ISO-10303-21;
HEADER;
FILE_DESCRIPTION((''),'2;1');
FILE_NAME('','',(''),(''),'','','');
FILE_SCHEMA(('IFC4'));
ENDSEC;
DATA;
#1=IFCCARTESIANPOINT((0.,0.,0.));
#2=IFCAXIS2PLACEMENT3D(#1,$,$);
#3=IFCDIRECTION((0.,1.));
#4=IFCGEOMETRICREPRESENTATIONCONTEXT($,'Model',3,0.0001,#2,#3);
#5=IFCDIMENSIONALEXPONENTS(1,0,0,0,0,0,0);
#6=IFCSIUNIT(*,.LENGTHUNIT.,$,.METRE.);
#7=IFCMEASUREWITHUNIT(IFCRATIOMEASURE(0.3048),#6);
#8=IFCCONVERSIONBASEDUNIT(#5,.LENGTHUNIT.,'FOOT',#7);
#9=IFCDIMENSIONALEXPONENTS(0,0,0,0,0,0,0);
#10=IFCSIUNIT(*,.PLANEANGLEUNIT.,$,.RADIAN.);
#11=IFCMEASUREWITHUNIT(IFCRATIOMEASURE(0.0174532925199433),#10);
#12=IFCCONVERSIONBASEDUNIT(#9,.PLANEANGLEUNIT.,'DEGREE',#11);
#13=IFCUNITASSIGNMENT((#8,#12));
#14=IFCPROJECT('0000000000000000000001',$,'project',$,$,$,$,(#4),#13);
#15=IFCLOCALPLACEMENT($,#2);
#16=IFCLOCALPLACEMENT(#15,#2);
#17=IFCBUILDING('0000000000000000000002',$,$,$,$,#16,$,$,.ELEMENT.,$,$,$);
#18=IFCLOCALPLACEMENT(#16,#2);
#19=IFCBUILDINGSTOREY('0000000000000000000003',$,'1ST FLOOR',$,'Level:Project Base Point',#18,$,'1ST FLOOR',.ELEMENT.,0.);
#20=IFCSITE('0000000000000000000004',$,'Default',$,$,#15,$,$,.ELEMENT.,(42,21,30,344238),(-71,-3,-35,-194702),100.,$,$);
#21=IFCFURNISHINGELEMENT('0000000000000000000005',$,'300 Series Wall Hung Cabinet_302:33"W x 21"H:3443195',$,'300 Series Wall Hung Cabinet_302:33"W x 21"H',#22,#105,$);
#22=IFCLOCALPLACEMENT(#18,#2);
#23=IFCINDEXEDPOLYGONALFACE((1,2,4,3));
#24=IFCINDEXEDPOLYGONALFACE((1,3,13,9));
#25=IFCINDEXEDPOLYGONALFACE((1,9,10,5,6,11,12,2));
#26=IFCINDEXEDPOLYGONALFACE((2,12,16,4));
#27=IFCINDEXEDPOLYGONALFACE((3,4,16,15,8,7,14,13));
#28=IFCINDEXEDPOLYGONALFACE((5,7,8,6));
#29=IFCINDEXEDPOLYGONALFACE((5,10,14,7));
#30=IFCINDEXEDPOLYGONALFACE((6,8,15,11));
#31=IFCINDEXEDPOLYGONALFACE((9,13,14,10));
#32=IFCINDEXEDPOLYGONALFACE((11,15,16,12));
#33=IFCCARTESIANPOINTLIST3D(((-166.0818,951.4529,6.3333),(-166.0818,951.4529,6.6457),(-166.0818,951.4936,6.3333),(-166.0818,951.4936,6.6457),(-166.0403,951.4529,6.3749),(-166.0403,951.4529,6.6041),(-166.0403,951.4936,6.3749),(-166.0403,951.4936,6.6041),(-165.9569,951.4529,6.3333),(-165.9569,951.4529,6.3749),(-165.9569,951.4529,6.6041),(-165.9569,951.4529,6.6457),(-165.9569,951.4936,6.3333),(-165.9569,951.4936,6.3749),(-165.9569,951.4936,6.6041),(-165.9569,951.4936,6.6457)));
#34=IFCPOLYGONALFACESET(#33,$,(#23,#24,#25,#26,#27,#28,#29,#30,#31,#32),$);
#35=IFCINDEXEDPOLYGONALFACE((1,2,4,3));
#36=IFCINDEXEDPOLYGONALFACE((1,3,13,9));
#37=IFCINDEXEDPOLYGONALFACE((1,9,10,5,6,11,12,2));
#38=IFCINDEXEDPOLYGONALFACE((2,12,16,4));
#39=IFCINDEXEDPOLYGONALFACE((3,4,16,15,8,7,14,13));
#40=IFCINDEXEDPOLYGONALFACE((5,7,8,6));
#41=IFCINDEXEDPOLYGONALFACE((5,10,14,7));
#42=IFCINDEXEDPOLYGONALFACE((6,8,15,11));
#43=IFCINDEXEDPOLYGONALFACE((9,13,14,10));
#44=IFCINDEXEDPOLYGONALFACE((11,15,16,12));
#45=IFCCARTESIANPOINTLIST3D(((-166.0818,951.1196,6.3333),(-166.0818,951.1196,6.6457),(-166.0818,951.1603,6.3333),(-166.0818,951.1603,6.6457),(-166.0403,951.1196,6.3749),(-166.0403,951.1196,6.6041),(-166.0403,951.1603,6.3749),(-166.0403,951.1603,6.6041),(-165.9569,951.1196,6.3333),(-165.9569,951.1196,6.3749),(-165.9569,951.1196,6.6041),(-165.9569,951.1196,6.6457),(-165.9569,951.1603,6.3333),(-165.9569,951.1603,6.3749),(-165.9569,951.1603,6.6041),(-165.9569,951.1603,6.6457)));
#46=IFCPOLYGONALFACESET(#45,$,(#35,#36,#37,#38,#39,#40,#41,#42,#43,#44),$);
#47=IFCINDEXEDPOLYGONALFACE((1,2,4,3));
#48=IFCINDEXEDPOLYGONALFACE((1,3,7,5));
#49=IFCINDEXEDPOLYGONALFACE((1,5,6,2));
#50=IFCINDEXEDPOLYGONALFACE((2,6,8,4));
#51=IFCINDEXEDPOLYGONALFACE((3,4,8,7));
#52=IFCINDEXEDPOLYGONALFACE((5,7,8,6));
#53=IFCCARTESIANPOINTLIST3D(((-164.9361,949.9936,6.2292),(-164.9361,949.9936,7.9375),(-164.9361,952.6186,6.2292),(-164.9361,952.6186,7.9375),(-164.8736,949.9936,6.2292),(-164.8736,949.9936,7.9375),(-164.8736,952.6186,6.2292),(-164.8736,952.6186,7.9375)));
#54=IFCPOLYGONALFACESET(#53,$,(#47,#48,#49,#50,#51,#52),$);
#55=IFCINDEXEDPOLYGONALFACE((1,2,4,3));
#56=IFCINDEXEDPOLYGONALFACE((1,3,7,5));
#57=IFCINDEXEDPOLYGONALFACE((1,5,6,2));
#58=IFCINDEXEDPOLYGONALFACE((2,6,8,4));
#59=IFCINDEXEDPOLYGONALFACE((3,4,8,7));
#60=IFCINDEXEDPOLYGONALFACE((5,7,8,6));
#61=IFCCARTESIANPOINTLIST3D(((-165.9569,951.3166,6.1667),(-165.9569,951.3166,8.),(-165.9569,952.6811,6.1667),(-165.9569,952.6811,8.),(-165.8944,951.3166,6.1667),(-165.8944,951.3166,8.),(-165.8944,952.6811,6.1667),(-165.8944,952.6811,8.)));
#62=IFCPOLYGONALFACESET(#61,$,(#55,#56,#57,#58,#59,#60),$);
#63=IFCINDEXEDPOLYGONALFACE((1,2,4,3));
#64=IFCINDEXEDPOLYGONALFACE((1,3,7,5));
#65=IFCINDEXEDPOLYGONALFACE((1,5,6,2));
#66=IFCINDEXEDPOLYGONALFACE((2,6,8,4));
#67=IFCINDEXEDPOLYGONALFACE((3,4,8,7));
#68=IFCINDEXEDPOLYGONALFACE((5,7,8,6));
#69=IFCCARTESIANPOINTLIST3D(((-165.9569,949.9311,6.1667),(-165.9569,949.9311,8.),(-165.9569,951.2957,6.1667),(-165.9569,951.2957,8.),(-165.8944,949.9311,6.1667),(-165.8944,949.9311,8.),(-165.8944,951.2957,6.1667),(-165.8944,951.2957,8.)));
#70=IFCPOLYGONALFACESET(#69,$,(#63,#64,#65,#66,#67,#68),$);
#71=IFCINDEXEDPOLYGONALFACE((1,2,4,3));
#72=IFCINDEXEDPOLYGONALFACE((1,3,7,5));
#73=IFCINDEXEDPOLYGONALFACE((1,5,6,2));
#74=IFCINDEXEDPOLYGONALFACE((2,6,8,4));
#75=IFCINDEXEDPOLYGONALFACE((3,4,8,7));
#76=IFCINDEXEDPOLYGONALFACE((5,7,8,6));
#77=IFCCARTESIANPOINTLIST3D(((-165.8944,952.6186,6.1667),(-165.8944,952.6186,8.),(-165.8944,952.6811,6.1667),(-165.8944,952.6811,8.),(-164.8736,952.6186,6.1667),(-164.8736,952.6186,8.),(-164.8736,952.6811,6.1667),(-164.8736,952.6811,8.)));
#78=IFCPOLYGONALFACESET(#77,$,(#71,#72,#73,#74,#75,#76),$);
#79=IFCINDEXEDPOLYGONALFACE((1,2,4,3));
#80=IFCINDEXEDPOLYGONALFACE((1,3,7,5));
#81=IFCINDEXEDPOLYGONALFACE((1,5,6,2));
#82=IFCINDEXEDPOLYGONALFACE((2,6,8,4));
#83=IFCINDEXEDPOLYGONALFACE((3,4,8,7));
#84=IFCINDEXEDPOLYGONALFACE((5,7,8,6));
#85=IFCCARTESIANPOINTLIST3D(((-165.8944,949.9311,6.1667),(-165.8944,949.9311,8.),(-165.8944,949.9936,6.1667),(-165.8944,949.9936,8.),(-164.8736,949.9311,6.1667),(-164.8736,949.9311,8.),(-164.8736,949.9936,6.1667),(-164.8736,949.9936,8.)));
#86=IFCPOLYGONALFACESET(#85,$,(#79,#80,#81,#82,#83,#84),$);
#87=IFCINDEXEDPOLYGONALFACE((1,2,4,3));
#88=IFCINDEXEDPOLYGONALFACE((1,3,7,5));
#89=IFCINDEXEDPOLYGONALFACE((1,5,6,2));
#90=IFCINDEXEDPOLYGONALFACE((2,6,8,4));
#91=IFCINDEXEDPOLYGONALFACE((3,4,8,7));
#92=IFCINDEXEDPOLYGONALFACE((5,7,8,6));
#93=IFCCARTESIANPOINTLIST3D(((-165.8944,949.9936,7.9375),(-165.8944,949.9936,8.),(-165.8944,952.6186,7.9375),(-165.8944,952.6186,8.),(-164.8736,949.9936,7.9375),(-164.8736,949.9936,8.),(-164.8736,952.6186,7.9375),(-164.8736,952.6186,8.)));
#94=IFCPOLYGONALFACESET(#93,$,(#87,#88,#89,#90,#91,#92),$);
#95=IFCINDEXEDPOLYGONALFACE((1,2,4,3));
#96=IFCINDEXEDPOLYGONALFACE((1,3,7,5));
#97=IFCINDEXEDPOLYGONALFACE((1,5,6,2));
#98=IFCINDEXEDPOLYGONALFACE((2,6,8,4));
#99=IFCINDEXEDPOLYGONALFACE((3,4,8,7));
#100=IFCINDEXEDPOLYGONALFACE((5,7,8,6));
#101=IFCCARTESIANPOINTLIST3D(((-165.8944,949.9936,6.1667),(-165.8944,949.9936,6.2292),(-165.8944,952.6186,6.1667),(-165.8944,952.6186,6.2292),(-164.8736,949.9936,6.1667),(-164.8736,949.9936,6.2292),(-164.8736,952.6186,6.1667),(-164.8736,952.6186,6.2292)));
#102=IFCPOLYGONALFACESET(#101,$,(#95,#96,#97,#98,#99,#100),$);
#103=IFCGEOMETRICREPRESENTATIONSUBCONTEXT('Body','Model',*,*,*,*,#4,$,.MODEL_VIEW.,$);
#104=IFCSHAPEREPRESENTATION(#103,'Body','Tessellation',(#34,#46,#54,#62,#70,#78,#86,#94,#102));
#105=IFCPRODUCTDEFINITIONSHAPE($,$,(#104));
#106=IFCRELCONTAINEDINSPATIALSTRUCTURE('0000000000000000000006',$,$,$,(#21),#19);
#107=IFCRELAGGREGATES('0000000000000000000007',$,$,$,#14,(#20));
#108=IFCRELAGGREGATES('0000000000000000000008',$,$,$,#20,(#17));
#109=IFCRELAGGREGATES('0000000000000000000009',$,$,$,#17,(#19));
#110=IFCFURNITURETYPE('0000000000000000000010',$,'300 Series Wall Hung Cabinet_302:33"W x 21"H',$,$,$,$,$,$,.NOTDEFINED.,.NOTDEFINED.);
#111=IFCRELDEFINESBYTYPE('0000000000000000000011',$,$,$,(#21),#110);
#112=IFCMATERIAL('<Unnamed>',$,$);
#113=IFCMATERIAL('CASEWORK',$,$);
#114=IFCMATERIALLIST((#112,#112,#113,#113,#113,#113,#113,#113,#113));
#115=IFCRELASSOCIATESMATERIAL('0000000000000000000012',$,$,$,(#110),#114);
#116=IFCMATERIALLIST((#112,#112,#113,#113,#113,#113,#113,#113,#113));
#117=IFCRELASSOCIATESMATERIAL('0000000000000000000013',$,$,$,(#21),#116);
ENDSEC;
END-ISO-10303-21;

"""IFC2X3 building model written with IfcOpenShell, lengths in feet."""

from ifc_helpers import new_model, entity, si_unit, converted_unit, direction, frame, frame_2d, origin, origin_2d_with_axis, place, context, subcontext, project, spatial, polyline, rectangle, outline, extrude, source, transform, mapped, material, material_list, type_object, type_shapes, element, save


model = new_model("IFC2X3")

# Units and contexts
model_context = context("Model", 3, precision=0.0001, world=origin(), true_north=direction((0.0, 1.0)))
body_context = subcontext(model_context, "Body", "Model", "MODEL_VIEW")
ifc_project = project(units=[converted_unit("LENGTHUNIT", "FOOT", entity("IfcRatioMeasure", 0.3048), si_unit("LENGTHUNIT", "METRE"), dimensions=[1, 0, 0, 0, 0, 0, 0]), converted_unit("PLANEANGLEUNIT", "DEGREE", entity("IfcRatioMeasure", 0.0174532925199433), si_unit("PLANEANGLEUNIT", "RADIAN"), dimensions=[0, 0, 0, 0, 0, 0, 0])], contexts=[model_context])

# Site, building, storey
site_placement = place(None, origin())
site = spatial("IfcSite", under=ifc_project, at=site_placement, Name="Default", CompositionType="ELEMENT", RefLatitude=(42, 21, 30, 344238), RefLongitude=(-71, -3, -35, -194702), RefElevation=100.0)
building_placement = place(site_placement, origin())
building = spatial("IfcBuilding", under=site, at=building_placement, CompositionType="ELEMENT")
storey_placement = place(building_placement, origin())
storey = spatial("IfcBuildingStorey", under=building, at=storey_placement, Name="1ST FLOOR", ObjectType="Level:Project Base Point", LongName="1ST FLOOR", CompositionType="ELEMENT", Elevation=0.0)

# Shared definitions
ifc_material_1 = material(Name="CASEWORK")

# Furnishing element
ifc_material_2 = material(Name="<Unnamed>")
ifc_material_list_1 = material_list([ifc_material_2, ifc_material_2, ifc_material_1, ifc_material_1, ifc_material_1, ifc_material_1, ifc_material_1, ifc_material_1, ifc_material_1])
ifc_material_list_2 = material_list([ifc_material_2, ifc_material_2, ifc_material_1, ifc_material_1, ifc_material_1, ifc_material_1, ifc_material_1, ifc_material_1, ifc_material_1])
furniture_type_1 = type_object("IfcFurnitureType", Name="300 Series Wall Hung Cabinet_302:33\"W x 21\"H", material=ifc_material_list_2)
shared_shape_1 = source(origin(), body_context, "Body", "SweptSolid", [
    extrude(outline(polyline([(0.1146, -0.0521), (0.1562, -0.0521), (0.1562, 0.0729), (-0.1562, 0.0729), (-0.1562, -0.0521), (-0.1146, -0.0521), (-0.1146, 0.0313), (0.1146, 0.0313), (0.1146, -0.0521)])), frame((1.1875, 0.0729, 0.3229), z_axis=(1.0, 0.0, 0.0), x_axis=(0.0, 0.0, 1.0)), (0.0, 0.0, 1.0), 0.0407),
    extrude(outline(polyline([(0.1146, -0.0521), (0.1562, -0.0521), (0.1562, 0.0729), (-0.1562, 0.0729), (-0.1562, -0.0521), (-0.1146, -0.0521), (-0.1146, 0.0313), (0.1146, 0.0313), (0.1146, -0.0521)])), frame((1.5208, 0.0729, 0.3229), z_axis=(1.0, 0.0, 0.0), x_axis=(0.0, 0.0, 1.0)), (0.0, 0.0, 1.0), 0.0407),
    extrude(rectangle(XDim=2.625, YDim=0.0625, at=origin_2d_with_axis()), frame((1.375, 1.177, 0.0625), z_axis=(0.0, 0.0, 1.0), x_axis=(-1.0, 0.0, 0.0)), (0.0, 0.0, 1.0), 1.7083),
    extrude(rectangle(XDim=1.3646, YDim=0.0625, at=frame_2d((0.0, 0.0), x_axis=(1.0, 0.0))), frame((0.6823, 0.1562, 0.0), z_axis=(0.0, 0.0, 1.0), x_axis=(-1.0, 0.0, 0.0)), (0.0, 0.0, 1.0), 1.8333),
    extrude(rectangle(XDim=1.3646, YDim=0.0625, at=origin_2d_with_axis()), frame((2.0677, 0.1562, 0.0), z_axis=(0.0, 0.0, 1.0), x_axis=(-1.0, 0.0, 0.0)), (0.0, 0.0, 1.0), 1.8333),
    extrude(rectangle(XDim=1.0208, YDim=0.0625, at=frame_2d((0.0, 0.0), x_axis=(1.0, 0.0))), frame((0.0313, 0.6979, 0.0), z_axis=(0.0, 0.0, 1.0), x_axis=(0.0, -1.0, 0.0)), (0.0, 0.0, 1.0), 1.8333),
    extrude(rectangle(XDim=1.0208, YDim=0.0625, at=frame_2d((0.0, 0.0), x_axis=(1.0, 0.0))), frame((2.7188, 0.6979, 0.0), z_axis=(0.0, 0.0, 1.0), x_axis=(0.0, -1.0, 0.0)), (0.0, 0.0, 1.0), 1.8333),
    extrude(rectangle(XDim=1.0208, YDim=2.625, at=origin_2d_with_axis()), frame((1.375, 0.6979, 1.7708), z_axis=(0.0, 0.0, 1.0), x_axis=(0.0, 1.0, 0.0)), (0.0, 0.0, 1.0), 0.0625),
    extrude(rectangle(XDim=1.0208, YDim=2.625, at=frame_2d((0.0, 0.0), x_axis=(1.0, 0.0))), frame((1.375, 0.6979, 0.0), z_axis=(0.0, 0.0, 1.0), x_axis=(0.0, 1.0, 0.0)), (0.0, 0.0, 1.0), 0.0625),
])
type_shapes(furniture_type_1, [shared_shape_1])
furnishing_1_placement = place(storey_placement, frame((-166.0818, 952.6811, 6.1667), z_axis=(0.0, 0.0, 1.0), x_axis=(0.0, -1.0, 0.0)))
element("IfcFurnishingElement", 1, at=furnishing_1_placement, inside=storey, type_object=furniture_type_1, material=ifc_material_list_1, Name="300 Series Wall Hung Cabinet_302:33\"W x 21\"H:3443195", ObjectType="300 Series Wall Hung Cabinet_302:33\"W x 21\"H", context=body_context, shape_type="MappedRepresentation", body=[
    mapped(shared_shape_1, transform((0.0, 0.0, 0.0), scale=1.0)),
])

save(model, "model.ifc")
